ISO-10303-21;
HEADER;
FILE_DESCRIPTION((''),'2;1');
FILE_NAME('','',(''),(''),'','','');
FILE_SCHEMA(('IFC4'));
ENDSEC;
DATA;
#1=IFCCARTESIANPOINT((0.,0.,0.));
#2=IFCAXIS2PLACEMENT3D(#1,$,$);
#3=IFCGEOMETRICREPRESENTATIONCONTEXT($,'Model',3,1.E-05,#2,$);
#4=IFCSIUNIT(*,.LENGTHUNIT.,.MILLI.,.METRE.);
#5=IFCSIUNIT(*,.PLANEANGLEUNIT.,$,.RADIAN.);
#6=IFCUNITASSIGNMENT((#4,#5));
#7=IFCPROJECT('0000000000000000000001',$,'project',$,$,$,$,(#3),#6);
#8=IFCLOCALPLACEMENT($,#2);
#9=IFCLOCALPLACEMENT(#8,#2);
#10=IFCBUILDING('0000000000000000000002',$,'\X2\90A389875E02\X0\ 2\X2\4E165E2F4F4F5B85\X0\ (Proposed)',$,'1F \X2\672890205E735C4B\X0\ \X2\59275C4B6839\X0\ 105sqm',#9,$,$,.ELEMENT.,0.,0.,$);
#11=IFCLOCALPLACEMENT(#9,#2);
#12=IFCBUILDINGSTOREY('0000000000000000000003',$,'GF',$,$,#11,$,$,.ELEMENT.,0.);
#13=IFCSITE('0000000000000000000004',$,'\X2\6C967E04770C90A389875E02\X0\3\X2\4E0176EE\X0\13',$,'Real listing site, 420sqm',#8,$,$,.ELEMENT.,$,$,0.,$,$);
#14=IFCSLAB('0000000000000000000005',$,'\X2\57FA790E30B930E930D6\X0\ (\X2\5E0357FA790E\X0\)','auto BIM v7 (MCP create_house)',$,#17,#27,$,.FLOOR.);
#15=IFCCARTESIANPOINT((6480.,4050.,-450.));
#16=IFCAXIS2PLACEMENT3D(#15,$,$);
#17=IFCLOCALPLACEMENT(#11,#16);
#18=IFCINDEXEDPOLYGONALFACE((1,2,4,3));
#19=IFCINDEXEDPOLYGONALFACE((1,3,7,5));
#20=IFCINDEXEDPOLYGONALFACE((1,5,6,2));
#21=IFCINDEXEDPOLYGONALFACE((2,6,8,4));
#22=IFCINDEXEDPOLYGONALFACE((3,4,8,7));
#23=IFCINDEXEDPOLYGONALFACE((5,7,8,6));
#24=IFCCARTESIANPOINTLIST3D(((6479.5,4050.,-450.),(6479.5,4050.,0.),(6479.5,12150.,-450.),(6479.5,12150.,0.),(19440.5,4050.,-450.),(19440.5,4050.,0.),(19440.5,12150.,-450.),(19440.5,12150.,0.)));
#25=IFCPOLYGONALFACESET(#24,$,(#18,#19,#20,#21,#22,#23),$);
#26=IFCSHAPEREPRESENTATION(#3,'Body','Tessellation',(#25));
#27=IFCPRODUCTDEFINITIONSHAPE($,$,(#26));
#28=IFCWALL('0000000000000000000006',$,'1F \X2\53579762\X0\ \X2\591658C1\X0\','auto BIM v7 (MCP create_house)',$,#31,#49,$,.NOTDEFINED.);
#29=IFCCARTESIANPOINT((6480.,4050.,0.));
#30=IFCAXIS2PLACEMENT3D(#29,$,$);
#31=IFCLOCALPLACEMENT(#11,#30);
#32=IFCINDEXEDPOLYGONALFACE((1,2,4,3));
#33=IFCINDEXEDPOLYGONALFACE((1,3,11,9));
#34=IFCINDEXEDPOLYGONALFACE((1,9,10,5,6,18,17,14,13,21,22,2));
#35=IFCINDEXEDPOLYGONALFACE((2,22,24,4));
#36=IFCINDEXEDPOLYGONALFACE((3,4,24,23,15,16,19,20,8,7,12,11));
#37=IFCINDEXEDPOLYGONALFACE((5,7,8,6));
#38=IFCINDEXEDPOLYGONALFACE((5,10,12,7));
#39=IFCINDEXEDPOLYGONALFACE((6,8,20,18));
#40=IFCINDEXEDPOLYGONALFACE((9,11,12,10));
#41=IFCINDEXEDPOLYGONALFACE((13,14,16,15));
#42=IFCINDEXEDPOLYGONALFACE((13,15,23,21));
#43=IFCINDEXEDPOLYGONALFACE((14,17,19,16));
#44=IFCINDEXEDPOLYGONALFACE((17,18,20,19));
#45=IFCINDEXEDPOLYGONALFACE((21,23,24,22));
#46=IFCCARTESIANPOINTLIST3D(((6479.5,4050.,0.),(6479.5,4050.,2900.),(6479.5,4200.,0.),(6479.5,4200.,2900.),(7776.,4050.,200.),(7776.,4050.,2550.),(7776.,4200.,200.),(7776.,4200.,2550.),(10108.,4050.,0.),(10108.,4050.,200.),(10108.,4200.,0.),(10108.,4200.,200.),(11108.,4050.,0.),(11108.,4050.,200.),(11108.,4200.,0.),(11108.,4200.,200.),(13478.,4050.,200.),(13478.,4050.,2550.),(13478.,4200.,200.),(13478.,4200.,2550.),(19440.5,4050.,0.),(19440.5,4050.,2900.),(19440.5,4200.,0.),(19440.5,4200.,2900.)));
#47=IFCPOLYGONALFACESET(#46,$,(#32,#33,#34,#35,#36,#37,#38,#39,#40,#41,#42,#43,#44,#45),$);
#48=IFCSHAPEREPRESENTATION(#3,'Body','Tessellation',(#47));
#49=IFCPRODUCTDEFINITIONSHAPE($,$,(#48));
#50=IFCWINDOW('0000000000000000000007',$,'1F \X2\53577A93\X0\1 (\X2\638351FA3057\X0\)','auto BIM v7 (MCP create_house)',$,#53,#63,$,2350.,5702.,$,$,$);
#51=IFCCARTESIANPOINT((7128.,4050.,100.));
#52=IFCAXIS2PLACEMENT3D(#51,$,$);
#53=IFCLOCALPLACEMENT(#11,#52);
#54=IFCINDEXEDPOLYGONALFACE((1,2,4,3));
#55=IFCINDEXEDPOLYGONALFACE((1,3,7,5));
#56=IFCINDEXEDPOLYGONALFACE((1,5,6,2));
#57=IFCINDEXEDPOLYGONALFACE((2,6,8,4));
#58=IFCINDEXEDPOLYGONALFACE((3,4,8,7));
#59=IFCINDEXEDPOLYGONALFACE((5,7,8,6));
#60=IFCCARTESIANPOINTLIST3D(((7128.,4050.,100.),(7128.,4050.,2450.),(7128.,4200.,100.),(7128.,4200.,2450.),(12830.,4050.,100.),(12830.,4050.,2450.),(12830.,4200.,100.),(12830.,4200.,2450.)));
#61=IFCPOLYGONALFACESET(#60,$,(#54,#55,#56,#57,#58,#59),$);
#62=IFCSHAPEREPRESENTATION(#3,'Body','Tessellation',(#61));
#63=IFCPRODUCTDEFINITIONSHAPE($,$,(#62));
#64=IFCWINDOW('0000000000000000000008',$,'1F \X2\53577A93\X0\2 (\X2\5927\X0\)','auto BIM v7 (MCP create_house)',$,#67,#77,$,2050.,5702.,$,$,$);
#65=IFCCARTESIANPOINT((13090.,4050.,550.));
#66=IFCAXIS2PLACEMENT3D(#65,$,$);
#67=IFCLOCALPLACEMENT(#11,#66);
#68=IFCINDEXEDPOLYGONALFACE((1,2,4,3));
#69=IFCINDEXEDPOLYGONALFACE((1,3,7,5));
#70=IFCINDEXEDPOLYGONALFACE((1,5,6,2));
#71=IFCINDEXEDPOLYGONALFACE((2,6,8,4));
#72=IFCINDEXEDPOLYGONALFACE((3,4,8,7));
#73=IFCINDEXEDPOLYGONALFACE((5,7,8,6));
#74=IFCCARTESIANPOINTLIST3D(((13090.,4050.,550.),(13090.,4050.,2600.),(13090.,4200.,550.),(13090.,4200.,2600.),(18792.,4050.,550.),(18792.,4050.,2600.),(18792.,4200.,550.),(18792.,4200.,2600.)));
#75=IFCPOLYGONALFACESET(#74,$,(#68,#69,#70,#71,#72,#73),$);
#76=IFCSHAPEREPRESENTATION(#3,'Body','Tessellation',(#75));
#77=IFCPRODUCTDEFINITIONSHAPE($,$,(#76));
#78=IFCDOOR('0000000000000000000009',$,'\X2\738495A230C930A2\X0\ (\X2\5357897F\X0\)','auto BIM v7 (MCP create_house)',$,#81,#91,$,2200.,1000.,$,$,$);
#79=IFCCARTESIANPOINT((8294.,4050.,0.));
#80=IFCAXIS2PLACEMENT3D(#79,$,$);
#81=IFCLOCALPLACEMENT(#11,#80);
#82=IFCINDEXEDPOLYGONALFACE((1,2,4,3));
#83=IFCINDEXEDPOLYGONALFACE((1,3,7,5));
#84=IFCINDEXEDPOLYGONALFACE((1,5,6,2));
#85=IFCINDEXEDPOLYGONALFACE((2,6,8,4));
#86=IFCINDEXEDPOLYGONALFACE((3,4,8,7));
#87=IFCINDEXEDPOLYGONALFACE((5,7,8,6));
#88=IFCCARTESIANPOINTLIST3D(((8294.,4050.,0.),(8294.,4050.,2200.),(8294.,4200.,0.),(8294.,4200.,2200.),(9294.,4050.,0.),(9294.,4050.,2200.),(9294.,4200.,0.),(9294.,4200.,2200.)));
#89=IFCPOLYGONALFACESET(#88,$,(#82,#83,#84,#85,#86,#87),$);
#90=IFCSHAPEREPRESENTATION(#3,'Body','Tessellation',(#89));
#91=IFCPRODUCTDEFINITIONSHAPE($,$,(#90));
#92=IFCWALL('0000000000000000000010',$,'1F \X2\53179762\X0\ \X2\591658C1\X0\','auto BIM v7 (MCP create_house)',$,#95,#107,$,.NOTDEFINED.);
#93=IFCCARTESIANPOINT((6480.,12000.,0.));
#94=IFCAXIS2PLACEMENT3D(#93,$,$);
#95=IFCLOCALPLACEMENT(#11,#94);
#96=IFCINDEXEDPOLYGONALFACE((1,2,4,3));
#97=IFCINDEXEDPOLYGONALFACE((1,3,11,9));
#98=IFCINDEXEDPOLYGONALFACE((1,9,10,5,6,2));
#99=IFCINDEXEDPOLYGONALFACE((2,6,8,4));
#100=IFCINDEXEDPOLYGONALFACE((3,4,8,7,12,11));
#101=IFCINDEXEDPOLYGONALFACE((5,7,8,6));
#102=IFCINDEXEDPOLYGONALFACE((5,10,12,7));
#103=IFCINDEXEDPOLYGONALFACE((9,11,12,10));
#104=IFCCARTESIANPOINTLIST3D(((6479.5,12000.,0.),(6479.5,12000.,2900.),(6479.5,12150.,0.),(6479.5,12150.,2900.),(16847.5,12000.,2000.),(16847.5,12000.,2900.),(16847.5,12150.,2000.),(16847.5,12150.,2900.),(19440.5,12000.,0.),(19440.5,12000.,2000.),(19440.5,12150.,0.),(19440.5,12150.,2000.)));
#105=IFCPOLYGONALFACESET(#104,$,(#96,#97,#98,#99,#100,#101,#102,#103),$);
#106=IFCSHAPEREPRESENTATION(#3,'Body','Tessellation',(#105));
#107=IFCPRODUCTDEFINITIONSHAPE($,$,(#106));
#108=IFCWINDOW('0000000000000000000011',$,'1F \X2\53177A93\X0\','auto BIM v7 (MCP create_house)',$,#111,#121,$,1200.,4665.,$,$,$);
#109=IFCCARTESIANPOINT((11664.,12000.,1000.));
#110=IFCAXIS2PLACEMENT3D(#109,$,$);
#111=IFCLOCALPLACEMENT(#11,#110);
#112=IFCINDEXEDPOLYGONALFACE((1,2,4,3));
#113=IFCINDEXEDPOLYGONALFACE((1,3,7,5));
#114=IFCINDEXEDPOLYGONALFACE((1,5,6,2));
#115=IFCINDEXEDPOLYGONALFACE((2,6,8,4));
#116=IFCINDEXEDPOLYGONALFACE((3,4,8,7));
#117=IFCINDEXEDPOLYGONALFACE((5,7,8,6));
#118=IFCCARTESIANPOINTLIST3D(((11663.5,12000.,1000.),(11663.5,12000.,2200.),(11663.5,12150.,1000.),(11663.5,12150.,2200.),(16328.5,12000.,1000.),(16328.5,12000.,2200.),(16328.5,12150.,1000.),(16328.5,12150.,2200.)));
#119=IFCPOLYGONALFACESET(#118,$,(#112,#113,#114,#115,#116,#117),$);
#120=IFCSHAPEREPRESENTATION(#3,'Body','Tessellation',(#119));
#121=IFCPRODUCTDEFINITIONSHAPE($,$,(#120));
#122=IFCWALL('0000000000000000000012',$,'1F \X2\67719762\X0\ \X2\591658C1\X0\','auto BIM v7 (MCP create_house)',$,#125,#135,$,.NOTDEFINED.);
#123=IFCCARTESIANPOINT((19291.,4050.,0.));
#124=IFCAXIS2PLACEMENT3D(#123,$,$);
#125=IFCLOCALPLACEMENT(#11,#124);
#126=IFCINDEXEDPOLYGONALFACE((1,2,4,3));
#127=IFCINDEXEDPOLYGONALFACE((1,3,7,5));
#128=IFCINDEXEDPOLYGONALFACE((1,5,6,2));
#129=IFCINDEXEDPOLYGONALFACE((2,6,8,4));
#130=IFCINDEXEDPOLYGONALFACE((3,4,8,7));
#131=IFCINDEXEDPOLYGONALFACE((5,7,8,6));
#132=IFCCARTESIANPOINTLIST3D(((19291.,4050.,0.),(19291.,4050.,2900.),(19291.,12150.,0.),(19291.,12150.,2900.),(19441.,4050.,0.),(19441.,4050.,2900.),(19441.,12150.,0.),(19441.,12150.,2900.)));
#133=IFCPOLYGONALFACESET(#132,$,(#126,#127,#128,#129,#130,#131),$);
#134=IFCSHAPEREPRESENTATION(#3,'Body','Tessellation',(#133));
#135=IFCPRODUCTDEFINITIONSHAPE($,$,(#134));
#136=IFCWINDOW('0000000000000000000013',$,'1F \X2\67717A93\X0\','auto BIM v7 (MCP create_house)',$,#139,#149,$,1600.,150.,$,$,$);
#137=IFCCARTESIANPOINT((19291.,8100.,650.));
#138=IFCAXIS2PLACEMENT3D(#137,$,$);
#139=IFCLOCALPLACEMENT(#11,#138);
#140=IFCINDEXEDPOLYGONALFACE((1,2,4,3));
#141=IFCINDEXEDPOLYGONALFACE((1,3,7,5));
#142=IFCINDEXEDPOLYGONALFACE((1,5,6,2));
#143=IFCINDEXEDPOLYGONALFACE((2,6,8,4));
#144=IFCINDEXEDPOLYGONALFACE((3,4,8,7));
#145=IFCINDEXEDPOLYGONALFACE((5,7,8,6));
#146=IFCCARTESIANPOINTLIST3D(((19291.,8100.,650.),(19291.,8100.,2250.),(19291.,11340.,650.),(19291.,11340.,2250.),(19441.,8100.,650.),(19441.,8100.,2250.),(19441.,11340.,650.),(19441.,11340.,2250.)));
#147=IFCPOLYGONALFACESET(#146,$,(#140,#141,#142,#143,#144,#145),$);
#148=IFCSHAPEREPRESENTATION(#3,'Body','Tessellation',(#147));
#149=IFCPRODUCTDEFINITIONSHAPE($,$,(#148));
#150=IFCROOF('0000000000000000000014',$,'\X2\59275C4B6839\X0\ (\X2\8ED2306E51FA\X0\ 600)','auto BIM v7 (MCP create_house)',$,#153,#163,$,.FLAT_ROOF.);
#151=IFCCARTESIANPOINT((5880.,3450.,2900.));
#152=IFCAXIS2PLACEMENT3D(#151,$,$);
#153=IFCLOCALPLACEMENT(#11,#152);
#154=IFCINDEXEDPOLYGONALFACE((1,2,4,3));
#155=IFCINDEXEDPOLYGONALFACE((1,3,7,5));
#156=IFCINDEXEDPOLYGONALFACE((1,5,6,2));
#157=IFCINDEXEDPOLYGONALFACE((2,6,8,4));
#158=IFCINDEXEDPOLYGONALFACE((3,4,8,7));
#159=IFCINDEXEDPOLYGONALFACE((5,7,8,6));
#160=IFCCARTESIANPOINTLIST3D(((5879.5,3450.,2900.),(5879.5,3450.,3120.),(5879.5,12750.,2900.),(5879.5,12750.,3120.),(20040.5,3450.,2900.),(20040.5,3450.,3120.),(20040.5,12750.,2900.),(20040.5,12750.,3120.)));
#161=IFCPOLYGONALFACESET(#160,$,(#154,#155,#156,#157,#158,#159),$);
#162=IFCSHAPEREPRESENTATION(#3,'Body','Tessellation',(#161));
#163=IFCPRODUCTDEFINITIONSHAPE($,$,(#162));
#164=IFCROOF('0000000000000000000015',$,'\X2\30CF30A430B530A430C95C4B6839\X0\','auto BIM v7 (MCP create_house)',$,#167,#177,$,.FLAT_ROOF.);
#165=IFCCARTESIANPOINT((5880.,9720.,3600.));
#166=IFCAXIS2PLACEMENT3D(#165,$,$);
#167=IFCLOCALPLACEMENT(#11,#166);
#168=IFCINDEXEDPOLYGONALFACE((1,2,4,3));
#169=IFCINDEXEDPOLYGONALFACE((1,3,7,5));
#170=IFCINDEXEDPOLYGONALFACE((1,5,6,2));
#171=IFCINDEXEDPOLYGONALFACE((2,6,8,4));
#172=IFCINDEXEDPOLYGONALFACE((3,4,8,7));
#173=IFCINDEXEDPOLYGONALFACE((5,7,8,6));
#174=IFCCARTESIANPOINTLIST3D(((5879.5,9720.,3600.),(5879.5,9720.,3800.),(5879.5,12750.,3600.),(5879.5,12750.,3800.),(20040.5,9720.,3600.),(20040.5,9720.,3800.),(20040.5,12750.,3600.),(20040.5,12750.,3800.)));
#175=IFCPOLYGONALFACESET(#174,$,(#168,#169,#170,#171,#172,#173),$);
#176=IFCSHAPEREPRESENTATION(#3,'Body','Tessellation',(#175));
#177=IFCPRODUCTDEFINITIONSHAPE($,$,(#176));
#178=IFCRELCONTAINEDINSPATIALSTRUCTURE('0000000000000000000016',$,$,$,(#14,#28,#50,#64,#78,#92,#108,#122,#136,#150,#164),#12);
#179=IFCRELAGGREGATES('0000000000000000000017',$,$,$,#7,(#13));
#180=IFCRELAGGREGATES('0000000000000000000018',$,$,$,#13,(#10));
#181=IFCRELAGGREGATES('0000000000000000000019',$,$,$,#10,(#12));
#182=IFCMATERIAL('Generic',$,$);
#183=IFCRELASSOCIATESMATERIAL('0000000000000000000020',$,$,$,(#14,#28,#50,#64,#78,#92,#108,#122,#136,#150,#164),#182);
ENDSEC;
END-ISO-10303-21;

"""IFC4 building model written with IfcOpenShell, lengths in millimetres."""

from ifc_helpers import new_model, si_unit, frame, frame_2d, origin, place, context, project, spatial, rectangle, extrude, material, element, fill, save


model = new_model("IFC4")

# Units and contexts
model_context = context("Model", 3, precision=1e-05, world=origin())
ifc_project = project(units=[si_unit("LENGTHUNIT", "METRE", prefix="MILLI"), si_unit("PLANEANGLEUNIT", "RADIAN")], contexts=[model_context])

# Site, building, storey
site_placement = place(None, origin())
site = spatial("IfcSite", under=ifc_project, at=site_placement, Name="沖縄県那覇市3丁目13", ObjectType="Real listing site, 420sqm", CompositionType="ELEMENT", RefElevation=0.0)
building_placement = place(site_placement, origin())
building = spatial("IfcBuilding", under=site, at=building_placement, Name="那覇市 2世帯住宅 (Proposed)", ObjectType="1F 木造平屋 大屋根 105sqm", CompositionType="ELEMENT", ElevationOfRefHeight=0.0, ElevationOfTerrain=0.0)
storey_placement = place(building_placement, origin())
storey = spatial("IfcBuildingStorey", under=building, at=storey_placement, Name="GF", CompositionType="ELEMENT", Elevation=0.0)

# Slab
ifc_material = material(Name="Generic")
slab_1_placement = place(storey_placement, frame((6480.0, 4050.0, -450.0)))
element("IfcSlab", 1, at=slab_1_placement, inside=storey, material=ifc_material, Name="基礎スラブ (布基礎)", Description="auto BIM v7 (MCP create_house)", PredefinedType="FLOOR", context=model_context, shape_type="SweptSolid", body=[
    extrude(rectangle(XDim=12961.0, YDim=8100.0, at=frame_2d((6480.0, 4050.0))), frame((6480.0, 4050.0, -450.0)), (0.0, 0.0, 1.0), 450.0),
])

# Wall, openings, windows, door
wall_1_placement = place(storey_placement, frame((6480.0, 4050.0, 0.0)))
wall_1 = element("IfcWall", 2, at=wall_1_placement, inside=storey, material=ifc_material, Name="1F 南面 外壁", Description="auto BIM v7 (MCP create_house)", PredefinedType="NOTDEFINED", context=model_context, shape_type="SweptSolid", body=[
    extrude(rectangle(XDim=12961.0, YDim=150.0, at=frame_2d((6480.0, 75.0))), frame((6480.0, 4050.0, 0.0)), (0.0, 0.0, 1.0), 2900.0),
])
opening_1_placement = place(storey_placement, frame((7128.0, 4050.0, 100.0)))
opening_1 = element("IfcOpeningElement", 3, at=opening_1_placement, cuts=wall_1, PredefinedType="NOTDEFINED", context=model_context, shape_type="SweptSolid", body=[
    extrude(rectangle(XDim=5702.0, YDim=150.0, at=frame_2d((2851.0, 75.0))), frame((7128.0, 4050.0, 100.0)), (0.0, 0.0, 1.0), 2350.0),
])
opening_2_placement = place(storey_placement, frame((13090.0, 4050.0, 550.0)))
opening_2 = element("IfcOpeningElement", 4, at=opening_2_placement, cuts=wall_1, PredefinedType="NOTDEFINED", context=model_context, shape_type="SweptSolid", body=[
    extrude(rectangle(XDim=5702.0, YDim=150.0, at=frame_2d((2851.0, 75.0))), frame((13090.0, 4050.0, 550.0)), (0.0, 0.0, 1.0), 2050.0),
])
opening_3_placement = place(storey_placement, frame((8294.0, 4050.0, 0.0)))
opening_3 = element("IfcOpeningElement", 5, at=opening_3_placement, cuts=wall_1, PredefinedType="NOTDEFINED", context=model_context, shape_type="SweptSolid", body=[
    extrude(rectangle(XDim=1000.0, YDim=150.0, at=frame_2d((500.0, 75.0))), frame((8294.0, 4050.0, 0.0)), (0.0, 0.0, 1.0), 2200.0),
])
window_1_placement = place(storey_placement, frame((7128.0, 4050.0, 100.0)))
window_1 = element("IfcWindow", 6, at=window_1_placement, inside=storey, material=ifc_material, Name="1F 南窓1 (掃出し)", Description="auto BIM v7 (MCP create_house)", OverallHeight=2350.0, OverallWidth=5702.0, context=model_context, shape_type="SweptSolid", body=[
    extrude(rectangle(XDim=5702.0, YDim=150.0, at=frame_2d((2851.0, 75.0))), frame((7128.0, 4050.0, 100.0)), (0.0, 0.0, 1.0), 2350.0),
])
fill(opening_1, window_1)
window_2_placement = place(storey_placement, frame((13090.0, 4050.0, 550.0)))
window_2 = element("IfcWindow", 7, at=window_2_placement, inside=storey, material=ifc_material, Name="1F 南窓2 (大)", Description="auto BIM v7 (MCP create_house)", OverallHeight=2050.0, OverallWidth=5702.0, context=model_context, shape_type="SweptSolid", body=[
    extrude(rectangle(XDim=5702.0, YDim=150.0, at=frame_2d((2851.0, 75.0))), frame((13090.0, 4050.0, 550.0)), (0.0, 0.0, 1.0), 2050.0),
])
fill(opening_2, window_2)
door_placement = place(storey_placement, frame((8294.0, 4050.0, 0.0)))
door = element("IfcDoor", 8, at=door_placement, inside=storey, material=ifc_material, Name="玄関ドア (南西)", Description="auto BIM v7 (MCP create_house)", OverallHeight=2200.0, OverallWidth=1000.0, context=model_context, shape_type="SweptSolid", body=[
    extrude(rectangle(XDim=1000.0, YDim=150.0, at=frame_2d((500.0, 75.0))), frame((8294.0, 4050.0, 0.0)), (0.0, 0.0, 1.0), 2200.0),
])
fill(opening_3, door)

# Walls, openings, windows
wall_2_placement = place(storey_placement, frame((6480.0, 12000.0, 0.0)))
wall_2 = element("IfcWall", 9, at=wall_2_placement, inside=storey, material=ifc_material, Name="1F 北面 外壁", Description="auto BIM v7 (MCP create_house)", PredefinedType="NOTDEFINED", context=model_context, shape_type="SweptSolid", body=[
    extrude(rectangle(XDim=12961.0, YDim=150.0, at=frame_2d((6480.0, 75.0))), frame((6480.0, 12000.0, 0.0)), (0.0, 0.0, 1.0), 2900.0),
])
opening_4_placement = place(storey_placement, frame((11664.0, 12000.0, 1000.0)))
opening_4 = element("IfcOpeningElement", 10, at=opening_4_placement, cuts=wall_2, PredefinedType="NOTDEFINED", context=model_context, shape_type="SweptSolid", body=[
    extrude(rectangle(XDim=4665.0, YDim=150.0, at=frame_2d((2332.0, 75.0))), frame((11664.0, 12000.0, 1000.0)), (0.0, 0.0, 1.0), 1200.0),
])
window_3_placement = place(storey_placement, frame((11664.0, 12000.0, 1000.0)))
window_3 = element("IfcWindow", 11, at=window_3_placement, inside=storey, material=ifc_material, Name="1F 北窓", Description="auto BIM v7 (MCP create_house)", OverallHeight=1200.0, OverallWidth=4665.0, context=model_context, shape_type="SweptSolid", body=[
    extrude(rectangle(XDim=4665.0, YDim=150.0, at=frame_2d((2332.0, 75.0))), frame((11664.0, 12000.0, 1000.0)), (0.0, 0.0, 1.0), 1200.0),
])
fill(opening_4, window_3)
wall_3_placement = place(storey_placement, frame((19291.0, 4050.0, 0.0)))
wall_3 = element("IfcWall", 12, at=wall_3_placement, inside=storey, material=ifc_material, Name="1F 東面 外壁", Description="auto BIM v7 (MCP create_house)", PredefinedType="NOTDEFINED", context=model_context, shape_type="SweptSolid", body=[
    extrude(rectangle(XDim=150.0, YDim=8100.0, at=frame_2d((75.0, 4050.0))), frame((19291.0, 4050.0, 0.0)), (0.0, 0.0, 1.0), 2900.0),
])
opening_5_placement = place(storey_placement, frame((19291.0, 8100.0, 650.0)))
opening_5 = element("IfcOpeningElement", 13, at=opening_5_placement, cuts=wall_3, PredefinedType="NOTDEFINED", context=model_context, shape_type="SweptSolid", body=[
    extrude(rectangle(XDim=150.0, YDim=3240.0, at=frame_2d((75.0, 1620.0))), frame((19291.0, 8100.0, 650.0)), (0.0, 0.0, 1.0), 1600.0),
])
window_4_placement = place(storey_placement, frame((19291.0, 8100.0, 650.0)))
window_4 = element("IfcWindow", 14, at=window_4_placement, inside=storey, material=ifc_material, Name="1F 東窓", Description="auto BIM v7 (MCP create_house)", OverallHeight=1600.0, OverallWidth=150.0, context=model_context, shape_type="SweptSolid", body=[
    extrude(rectangle(XDim=150.0, YDim=3240.0, at=frame_2d((75.0, 1620.0))), frame((19291.0, 8100.0, 650.0)), (0.0, 0.0, 1.0), 1600.0),
])
fill(opening_5, window_4)

# Roofs
roof_1_placement = place(storey_placement, frame((5880.0, 3450.0, 2900.0)))
element("IfcRoof", 15, at=roof_1_placement, inside=storey, material=ifc_material, Name="大屋根 (軒の出 600)", Description="auto BIM v7 (MCP create_house)", PredefinedType="FLAT_ROOF", context=model_context, shape_type="SweptSolid", body=[
    extrude(rectangle(XDim=14161.0, YDim=9300.0, at=frame_2d((7080.0, 4650.0))), frame((5880.0, 3450.0, 2900.0)), (0.0, 0.0, 1.0), 220.0),
])
roof_2_placement = place(storey_placement, frame((5880.0, 9720.0, 3600.0)))
element("IfcRoof", 16, at=roof_2_placement, inside=storey, material=ifc_material, Name="ハイサイド屋根", Description="auto BIM v7 (MCP create_house)", PredefinedType="FLAT_ROOF", context=model_context, shape_type="SweptSolid", body=[
    extrude(rectangle(XDim=14161.0, YDim=3030.0, at=frame_2d((7080.0, 1515.0))), frame((5880.0, 9720.0, 3600.0)), (0.0, 0.0, 1.0), 200.0),
])

save(model, "model.ifc")
